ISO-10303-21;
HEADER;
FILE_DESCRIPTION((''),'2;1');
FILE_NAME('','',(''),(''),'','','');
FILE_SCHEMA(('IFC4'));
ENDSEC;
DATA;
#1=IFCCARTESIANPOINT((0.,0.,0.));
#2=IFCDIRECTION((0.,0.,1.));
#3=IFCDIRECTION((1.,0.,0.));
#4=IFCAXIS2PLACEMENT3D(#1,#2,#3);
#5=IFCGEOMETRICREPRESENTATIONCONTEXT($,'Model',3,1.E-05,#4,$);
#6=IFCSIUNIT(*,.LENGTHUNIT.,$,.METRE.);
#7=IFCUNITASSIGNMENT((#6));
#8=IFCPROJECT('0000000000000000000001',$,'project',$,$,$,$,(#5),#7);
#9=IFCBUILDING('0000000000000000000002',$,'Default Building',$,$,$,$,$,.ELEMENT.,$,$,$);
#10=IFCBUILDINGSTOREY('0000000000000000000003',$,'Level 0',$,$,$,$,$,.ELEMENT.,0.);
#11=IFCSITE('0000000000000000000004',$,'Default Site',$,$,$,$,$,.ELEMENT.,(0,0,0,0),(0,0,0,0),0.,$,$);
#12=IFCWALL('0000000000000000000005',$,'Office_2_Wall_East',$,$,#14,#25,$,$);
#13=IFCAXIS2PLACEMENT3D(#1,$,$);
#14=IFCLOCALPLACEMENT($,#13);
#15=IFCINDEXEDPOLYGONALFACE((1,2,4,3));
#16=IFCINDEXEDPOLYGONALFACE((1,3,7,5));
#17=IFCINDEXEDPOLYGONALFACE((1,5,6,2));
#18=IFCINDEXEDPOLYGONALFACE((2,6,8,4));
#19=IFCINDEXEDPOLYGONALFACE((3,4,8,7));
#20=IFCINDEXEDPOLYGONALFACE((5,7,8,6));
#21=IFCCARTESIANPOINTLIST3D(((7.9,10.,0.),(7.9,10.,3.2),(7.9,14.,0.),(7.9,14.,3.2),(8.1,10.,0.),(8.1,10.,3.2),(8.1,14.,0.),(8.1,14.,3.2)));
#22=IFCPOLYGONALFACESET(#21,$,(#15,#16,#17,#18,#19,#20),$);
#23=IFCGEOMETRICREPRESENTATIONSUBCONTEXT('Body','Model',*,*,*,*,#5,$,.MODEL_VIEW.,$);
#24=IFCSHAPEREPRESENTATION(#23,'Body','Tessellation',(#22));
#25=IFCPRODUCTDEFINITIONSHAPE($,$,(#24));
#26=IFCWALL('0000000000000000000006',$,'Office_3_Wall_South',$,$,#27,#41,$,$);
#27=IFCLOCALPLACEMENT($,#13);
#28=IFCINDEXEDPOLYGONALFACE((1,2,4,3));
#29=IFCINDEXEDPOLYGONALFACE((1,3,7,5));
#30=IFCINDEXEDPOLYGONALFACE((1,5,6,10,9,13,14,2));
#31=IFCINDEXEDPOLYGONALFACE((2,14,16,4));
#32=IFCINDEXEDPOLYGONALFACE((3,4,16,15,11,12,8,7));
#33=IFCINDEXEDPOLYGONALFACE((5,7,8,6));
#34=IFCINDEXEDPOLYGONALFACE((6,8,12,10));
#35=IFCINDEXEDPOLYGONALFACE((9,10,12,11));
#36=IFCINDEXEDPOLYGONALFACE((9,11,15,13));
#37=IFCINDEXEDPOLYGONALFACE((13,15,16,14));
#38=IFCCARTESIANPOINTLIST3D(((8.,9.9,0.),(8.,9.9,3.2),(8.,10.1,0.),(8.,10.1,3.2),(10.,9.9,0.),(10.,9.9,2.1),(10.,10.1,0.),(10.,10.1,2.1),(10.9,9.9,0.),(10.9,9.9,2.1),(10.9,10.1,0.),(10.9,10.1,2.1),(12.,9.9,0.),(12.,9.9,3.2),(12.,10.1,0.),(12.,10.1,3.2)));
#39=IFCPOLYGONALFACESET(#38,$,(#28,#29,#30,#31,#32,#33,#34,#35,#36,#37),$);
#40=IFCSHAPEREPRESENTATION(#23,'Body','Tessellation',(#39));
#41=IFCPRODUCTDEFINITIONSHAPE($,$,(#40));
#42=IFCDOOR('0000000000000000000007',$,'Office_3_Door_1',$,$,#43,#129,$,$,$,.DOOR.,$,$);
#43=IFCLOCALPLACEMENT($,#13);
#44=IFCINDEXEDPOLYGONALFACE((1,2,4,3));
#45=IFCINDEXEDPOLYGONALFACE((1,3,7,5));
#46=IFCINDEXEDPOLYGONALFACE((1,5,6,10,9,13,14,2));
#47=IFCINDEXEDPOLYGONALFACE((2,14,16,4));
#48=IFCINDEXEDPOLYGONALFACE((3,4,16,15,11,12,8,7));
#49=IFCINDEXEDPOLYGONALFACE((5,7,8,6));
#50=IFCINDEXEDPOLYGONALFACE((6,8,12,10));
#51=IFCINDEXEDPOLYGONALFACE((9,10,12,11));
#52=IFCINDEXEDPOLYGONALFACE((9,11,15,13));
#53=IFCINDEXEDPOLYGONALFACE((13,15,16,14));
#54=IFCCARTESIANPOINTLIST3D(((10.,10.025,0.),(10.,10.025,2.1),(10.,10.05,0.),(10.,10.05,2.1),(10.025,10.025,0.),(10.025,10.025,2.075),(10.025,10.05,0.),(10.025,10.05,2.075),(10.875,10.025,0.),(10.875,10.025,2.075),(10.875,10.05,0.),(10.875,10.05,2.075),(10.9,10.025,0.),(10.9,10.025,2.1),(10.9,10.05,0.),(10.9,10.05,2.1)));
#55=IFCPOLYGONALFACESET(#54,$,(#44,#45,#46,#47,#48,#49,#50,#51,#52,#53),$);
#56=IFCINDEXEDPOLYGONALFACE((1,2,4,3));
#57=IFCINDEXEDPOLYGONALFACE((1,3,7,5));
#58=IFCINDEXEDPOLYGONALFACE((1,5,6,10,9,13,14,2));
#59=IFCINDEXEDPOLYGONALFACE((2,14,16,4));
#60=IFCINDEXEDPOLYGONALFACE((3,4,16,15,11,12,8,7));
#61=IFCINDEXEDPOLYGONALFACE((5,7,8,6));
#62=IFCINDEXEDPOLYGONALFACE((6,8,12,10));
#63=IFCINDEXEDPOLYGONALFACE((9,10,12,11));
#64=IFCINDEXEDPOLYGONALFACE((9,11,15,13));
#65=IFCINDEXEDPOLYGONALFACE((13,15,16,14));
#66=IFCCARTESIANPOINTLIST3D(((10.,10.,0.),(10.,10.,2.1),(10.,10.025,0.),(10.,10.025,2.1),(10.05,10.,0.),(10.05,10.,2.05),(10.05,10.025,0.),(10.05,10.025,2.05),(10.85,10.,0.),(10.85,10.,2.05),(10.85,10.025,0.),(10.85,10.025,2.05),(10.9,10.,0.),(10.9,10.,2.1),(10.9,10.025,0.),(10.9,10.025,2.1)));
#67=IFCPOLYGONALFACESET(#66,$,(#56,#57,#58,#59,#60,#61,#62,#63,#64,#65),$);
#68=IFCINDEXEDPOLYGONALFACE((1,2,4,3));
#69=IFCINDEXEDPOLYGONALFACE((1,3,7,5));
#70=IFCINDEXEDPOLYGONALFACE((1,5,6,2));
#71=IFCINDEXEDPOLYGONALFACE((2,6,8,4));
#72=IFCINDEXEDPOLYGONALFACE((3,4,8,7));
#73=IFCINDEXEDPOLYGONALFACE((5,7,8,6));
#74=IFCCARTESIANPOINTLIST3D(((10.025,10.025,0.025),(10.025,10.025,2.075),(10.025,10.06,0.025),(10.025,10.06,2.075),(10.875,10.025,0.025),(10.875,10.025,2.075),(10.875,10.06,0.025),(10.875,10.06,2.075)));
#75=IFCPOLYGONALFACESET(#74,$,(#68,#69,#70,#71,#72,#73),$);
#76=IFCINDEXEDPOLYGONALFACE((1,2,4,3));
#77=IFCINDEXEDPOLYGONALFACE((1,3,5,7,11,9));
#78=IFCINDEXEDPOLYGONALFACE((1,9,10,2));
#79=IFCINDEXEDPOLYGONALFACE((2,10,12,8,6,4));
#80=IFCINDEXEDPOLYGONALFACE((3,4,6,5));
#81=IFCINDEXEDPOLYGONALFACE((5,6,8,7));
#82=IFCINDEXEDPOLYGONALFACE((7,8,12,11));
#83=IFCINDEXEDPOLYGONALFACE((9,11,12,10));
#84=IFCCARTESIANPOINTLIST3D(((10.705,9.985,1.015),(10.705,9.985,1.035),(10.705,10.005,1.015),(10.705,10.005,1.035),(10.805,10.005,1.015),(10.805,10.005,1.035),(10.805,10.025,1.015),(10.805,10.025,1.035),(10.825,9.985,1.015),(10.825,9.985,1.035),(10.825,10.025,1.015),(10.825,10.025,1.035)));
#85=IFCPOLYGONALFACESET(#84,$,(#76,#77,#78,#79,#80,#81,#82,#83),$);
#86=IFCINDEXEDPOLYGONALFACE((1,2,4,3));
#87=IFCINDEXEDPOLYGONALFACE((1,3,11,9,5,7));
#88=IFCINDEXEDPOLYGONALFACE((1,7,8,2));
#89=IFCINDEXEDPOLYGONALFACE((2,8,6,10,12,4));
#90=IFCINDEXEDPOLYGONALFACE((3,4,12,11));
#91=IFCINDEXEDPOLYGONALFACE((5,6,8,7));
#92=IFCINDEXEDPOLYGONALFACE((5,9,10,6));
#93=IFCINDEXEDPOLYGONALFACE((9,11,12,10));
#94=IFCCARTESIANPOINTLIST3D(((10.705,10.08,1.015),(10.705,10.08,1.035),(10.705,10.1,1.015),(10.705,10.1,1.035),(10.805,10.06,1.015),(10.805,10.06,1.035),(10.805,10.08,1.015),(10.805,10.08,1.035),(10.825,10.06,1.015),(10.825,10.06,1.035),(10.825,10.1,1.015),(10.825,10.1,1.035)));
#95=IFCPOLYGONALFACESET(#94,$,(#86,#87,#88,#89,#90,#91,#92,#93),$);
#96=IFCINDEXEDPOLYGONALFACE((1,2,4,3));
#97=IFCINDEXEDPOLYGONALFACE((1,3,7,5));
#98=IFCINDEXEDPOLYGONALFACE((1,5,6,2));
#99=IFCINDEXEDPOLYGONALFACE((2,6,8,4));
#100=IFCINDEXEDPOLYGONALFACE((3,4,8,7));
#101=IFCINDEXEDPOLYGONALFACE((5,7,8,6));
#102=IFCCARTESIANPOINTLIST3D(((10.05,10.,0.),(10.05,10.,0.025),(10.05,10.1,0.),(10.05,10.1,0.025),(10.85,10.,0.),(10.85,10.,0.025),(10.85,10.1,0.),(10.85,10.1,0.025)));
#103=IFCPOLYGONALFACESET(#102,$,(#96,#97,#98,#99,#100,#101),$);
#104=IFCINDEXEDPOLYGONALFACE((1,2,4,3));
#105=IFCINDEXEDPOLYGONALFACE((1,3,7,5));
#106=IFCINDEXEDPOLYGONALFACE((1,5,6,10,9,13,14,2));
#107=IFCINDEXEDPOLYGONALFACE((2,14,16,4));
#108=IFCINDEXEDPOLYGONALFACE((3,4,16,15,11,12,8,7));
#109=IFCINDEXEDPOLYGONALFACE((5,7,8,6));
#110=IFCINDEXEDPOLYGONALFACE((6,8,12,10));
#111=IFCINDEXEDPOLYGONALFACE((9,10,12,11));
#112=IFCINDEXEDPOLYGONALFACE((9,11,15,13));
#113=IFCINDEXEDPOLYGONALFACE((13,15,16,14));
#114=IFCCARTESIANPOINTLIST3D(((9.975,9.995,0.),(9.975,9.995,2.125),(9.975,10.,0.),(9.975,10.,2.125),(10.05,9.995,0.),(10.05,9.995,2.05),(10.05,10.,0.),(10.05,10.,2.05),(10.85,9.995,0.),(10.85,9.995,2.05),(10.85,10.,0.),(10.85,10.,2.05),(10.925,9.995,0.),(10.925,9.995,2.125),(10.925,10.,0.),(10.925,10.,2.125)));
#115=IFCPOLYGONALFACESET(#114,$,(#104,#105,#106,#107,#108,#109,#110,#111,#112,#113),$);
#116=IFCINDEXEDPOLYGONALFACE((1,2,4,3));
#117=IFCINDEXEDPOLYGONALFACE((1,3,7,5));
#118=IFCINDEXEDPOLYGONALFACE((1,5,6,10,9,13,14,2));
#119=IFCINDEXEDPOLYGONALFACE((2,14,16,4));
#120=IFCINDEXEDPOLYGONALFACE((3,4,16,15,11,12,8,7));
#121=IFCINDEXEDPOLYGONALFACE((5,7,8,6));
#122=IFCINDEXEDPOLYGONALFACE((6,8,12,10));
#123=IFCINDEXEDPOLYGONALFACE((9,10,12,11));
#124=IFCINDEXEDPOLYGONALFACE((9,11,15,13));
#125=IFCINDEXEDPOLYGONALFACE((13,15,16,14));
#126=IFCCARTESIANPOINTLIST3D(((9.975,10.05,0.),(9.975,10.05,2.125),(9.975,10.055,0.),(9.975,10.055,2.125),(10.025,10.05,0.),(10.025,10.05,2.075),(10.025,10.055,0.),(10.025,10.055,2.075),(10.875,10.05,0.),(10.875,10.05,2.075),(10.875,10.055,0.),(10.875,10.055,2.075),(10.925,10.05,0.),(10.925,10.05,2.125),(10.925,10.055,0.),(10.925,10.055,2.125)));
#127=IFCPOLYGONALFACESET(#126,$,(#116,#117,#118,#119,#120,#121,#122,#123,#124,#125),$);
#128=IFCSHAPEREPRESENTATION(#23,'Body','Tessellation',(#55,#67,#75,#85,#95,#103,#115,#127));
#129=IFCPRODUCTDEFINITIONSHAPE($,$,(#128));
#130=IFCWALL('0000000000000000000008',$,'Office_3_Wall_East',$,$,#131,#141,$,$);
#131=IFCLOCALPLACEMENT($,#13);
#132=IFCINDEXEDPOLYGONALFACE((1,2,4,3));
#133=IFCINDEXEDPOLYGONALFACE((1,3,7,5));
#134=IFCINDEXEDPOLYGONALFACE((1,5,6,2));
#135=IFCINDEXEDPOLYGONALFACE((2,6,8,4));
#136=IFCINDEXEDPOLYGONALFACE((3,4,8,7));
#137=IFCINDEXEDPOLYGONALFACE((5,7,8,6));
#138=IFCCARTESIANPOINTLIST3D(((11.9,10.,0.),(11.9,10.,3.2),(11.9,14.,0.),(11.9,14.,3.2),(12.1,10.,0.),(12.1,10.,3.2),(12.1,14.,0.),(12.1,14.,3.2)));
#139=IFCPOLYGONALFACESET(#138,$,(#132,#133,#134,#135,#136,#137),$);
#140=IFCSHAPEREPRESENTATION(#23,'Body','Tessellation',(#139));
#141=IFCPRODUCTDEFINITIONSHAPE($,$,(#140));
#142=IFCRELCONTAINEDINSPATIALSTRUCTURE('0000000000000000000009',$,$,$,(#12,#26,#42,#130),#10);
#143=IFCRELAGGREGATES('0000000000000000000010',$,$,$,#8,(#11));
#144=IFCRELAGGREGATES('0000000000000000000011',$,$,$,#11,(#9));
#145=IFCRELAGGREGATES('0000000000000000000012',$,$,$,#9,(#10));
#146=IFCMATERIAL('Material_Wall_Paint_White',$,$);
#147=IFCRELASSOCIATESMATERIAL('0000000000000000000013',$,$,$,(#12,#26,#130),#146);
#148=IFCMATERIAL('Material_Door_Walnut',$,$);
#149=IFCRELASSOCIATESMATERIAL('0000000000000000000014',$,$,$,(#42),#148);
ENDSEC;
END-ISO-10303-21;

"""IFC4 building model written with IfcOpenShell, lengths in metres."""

from ifc_helpers import new_model, si_unit, frame, origin_with_axes, place, context, subcontext, project, spatial, line, indexed_curve, outline, extrude, material, element, fill, save


model = new_model("IFC4")

# Units and contexts
model_context = context("Model", 3, precision=1e-05, world=origin_with_axes())
body_context = subcontext(model_context, "Body", "Model", "MODEL_VIEW")
ifc_project = project(units=[si_unit("LENGTHUNIT", "METRE")], contexts=[model_context])

# Site, building, storey
site = spatial("IfcSite", under=ifc_project, Name="Default Site", CompositionType="ELEMENT", RefLatitude=(0, 0, 0, 0), RefLongitude=(0, 0, 0, 0), RefElevation=0.0)
building = spatial("IfcBuilding", under=site, Name="Default Building", CompositionType="ELEMENT")
storey = spatial("IfcBuildingStorey", under=building, Name="Level 0", CompositionType="ELEMENT", Elevation=0.0)

# Shared definitions
ifc_material_1 = material(Name="Material_Wall_Paint_White")

# Shared definitions
ifc_material_2 = material(Name="Material_Door_Walnut")

# Wall
wall_1_placement = place(None, frame((8.0, 10.0, 0.0), z_axis=(0.0, 0.0, 1.0), x_axis=(0.0, 1.0, 0.0)))
element("IfcWall", 1, at=wall_1_placement, inside=storey, material=ifc_material_1, Name="Office_2_Wall_East", context=body_context, shape_type="SweptSolid", body=[
    extrude(outline(indexed_curve([(0.0, 0.0), (0.0, 0.2), (4.0, 0.2), (4.0, 0.0), (0.0, 0.0)], self_intersect=False)), frame((0.0, -0.1, 0.0), z_axis=(0.0, 0.0, 1.0), x_axis=(1.0, 0.0, 0.0)), (0.0, 0.0, 1.0), 3.2),
])

# Wall, opening, door
wall_2_placement = place(None, frame((8.0, 10.0, 0.0), z_axis=(0.0, 0.0, 1.0), x_axis=(1.0, 0.0, 0.0)))
wall_2 = element("IfcWall", 2, at=wall_2_placement, inside=storey, material=ifc_material_1, Name="Office_3_Wall_South", context=body_context, shape_type="SweptSolid", body=[
    extrude(outline(indexed_curve([(0.0, 0.0), (0.0, 0.2), (4.0, 0.2), (4.0, 0.0), (0.0, 0.0)], self_intersect=False)), frame((0.0, -0.1, 0.0), z_axis=(0.0, 0.0, 1.0), x_axis=(1.0, 0.0, 0.0)), (0.0, 0.0, 1.0), 3.2),
])
opening_1_placement = place(wall_2_placement, frame((2.0, -0.5, 0.0), z_axis=(0.0, 0.0, 1.0), x_axis=(1.0, 0.0, 0.0)))
opening_1 = element("IfcOpeningElement", 3, at=opening_1_placement, inside=storey, cuts=wall_2, PredefinedType="OPENING", context=body_context, shape_type="SweptSolid", body=[
    extrude(outline(indexed_curve([(0.0, 0.0), (0.0, 1.0), (0.9, 1.0), (0.9, 0.0), (0.0, 0.0)], self_intersect=False)), origin_with_axes(), (0.0, 0.0, 1.0), 2.1),
])
door_1_placement = place(None, frame((10.0, 10.0, 0.0), z_axis=(0.0, 0.0, 1.0), x_axis=(1.0, 0.0, 0.0)))
door_1 = element("IfcDoor", 4, at=door_1_placement, inside=storey, material=ifc_material_2, Name="Office_3_Door_1", PredefinedType="DOOR", context=body_context, shape_type="SweptSolid", body=[
    extrude(outline(indexed_curve([(0.0, 0.0), (0.0, 2.1), (0.9, 2.1), (0.9, 0.0), (0.875, 0.0), (0.875, 2.075), (0.025, 2.075), (0.025, 0.0)], segments=[line(1, 2, 3, 4, 5, 6, 7, 8, 1)])), frame((0.0, 0.025, 0.0), z_axis=(0.0, -1.0, 0.0), x_axis=(1.0, 0.0, 0.0)), (0.0, 0.0, -1.0), 0.025),
    extrude(outline(indexed_curve([(0.0, 0.0), (0.0, 2.1), (0.9, 2.1), (0.9, 0.0), (0.85, 0.0), (0.85, 2.05), (0.05, 2.05), (0.05, 0.0)], segments=[line(1, 2, 3, 4, 5, 6, 7, 8, 1)])), frame((0.0, 0.0, 0.0), z_axis=(0.0, -1.0, 0.0), x_axis=(1.0, 0.0, 0.0)), (0.0, 0.0, -1.0), 0.025),
    extrude(outline(indexed_curve([(0.0, 0.0), (0.85, 0.0), (0.85, 0.035), (0.0, 0.035)], segments=[line(1, 2, 3, 4, 1)])), frame((0.025, 0.025, 0.025), z_axis=(0.0, 0.0, 1.0), x_axis=(1.0, 0.0, 0.0)), (0.0, 0.0, 1.0), 2.05),
    extrude(outline(indexed_curve([(0.0, 0.0), (0.0, -0.04), (-0.12, -0.04), (-0.12, -0.02), (-0.02, -0.02), (-0.02, 0.0)], segments=[line(1, 2, 3, 4, 5, 6, 1)])), frame((0.825, 0.025, 1.015), z_axis=(0.0, 0.0, 1.0), x_axis=(1.0, 0.0, 0.0)), (0.0, 0.0, 1.0), 0.02),
    extrude(outline(indexed_curve([(0.0, 0.0), (0.0, 0.04), (-0.12, 0.04), (-0.12, 0.02), (-0.02, 0.02), (-0.02, 0.0)], segments=[line(1, 2, 3, 4, 5, 6, 1)])), frame((0.825, 0.06, 1.015), z_axis=(0.0, 0.0, 1.0), x_axis=(1.0, 0.0, 0.0)), (0.0, 0.0, 1.0), 0.02),
    extrude(outline(indexed_curve([(0.0, 0.0), (0.8, 0.0), (0.8, 0.1), (0.0, 0.1)], segments=[line(1, 2, 3, 4, 1)])), frame((0.05, 0.0, 0.0), z_axis=(0.0, 0.0, 1.0), x_axis=(1.0, 0.0, 0.0)), (0.0, 0.0, 1.0), 0.025),
    extrude(outline(indexed_curve([(0.0, 0.0), (0.0, 2.125), (0.95, 2.125), (0.95, 0.0), (0.875, 0.0), (0.875, 2.05), (0.075, 2.05), (0.075, 0.0)], segments=[line(1, 2, 3, 4, 5, 6, 7, 8, 1)])), frame((-0.025, -0.005, 0.0), z_axis=(0.0, -1.0, 0.0), x_axis=(1.0, 0.0, 0.0)), (0.0, 0.0, -1.0), 0.005),
    extrude(outline(indexed_curve([(0.0, 0.0), (0.0, 2.125), (0.95, 2.125), (0.95, 0.0), (0.9, 0.0), (0.9, 2.075), (0.05, 2.075), (0.05, 0.0)], segments=[line(1, 2, 3, 4, 5, 6, 7, 8, 1)])), frame((-0.025, 0.05, 0.0), z_axis=(0.0, -1.0, 0.0), x_axis=(1.0, 0.0, 0.0)), (0.0, 0.0, -1.0), 0.005),
])
fill(opening_1, door_1)

# Wall
wall_3_placement = place(None, frame((12.0, 10.0, 0.0), z_axis=(0.0, 0.0, 1.0), x_axis=(0.0, 1.0, 0.0)))
element("IfcWall", 5, at=wall_3_placement, inside=storey, material=ifc_material_1, Name="Office_3_Wall_East", context=body_context, shape_type="SweptSolid", body=[
    extrude(outline(indexed_curve([(0.0, 0.0), (0.0, 0.2), (4.0, 0.2), (4.0, 0.0), (0.0, 0.0)], self_intersect=False)), frame((0.0, -0.1, 0.0), z_axis=(0.0, 0.0, 1.0), x_axis=(1.0, 0.0, 0.0)), (0.0, 0.0, 1.0), 3.2),
])

save(model, "model.ifc")
